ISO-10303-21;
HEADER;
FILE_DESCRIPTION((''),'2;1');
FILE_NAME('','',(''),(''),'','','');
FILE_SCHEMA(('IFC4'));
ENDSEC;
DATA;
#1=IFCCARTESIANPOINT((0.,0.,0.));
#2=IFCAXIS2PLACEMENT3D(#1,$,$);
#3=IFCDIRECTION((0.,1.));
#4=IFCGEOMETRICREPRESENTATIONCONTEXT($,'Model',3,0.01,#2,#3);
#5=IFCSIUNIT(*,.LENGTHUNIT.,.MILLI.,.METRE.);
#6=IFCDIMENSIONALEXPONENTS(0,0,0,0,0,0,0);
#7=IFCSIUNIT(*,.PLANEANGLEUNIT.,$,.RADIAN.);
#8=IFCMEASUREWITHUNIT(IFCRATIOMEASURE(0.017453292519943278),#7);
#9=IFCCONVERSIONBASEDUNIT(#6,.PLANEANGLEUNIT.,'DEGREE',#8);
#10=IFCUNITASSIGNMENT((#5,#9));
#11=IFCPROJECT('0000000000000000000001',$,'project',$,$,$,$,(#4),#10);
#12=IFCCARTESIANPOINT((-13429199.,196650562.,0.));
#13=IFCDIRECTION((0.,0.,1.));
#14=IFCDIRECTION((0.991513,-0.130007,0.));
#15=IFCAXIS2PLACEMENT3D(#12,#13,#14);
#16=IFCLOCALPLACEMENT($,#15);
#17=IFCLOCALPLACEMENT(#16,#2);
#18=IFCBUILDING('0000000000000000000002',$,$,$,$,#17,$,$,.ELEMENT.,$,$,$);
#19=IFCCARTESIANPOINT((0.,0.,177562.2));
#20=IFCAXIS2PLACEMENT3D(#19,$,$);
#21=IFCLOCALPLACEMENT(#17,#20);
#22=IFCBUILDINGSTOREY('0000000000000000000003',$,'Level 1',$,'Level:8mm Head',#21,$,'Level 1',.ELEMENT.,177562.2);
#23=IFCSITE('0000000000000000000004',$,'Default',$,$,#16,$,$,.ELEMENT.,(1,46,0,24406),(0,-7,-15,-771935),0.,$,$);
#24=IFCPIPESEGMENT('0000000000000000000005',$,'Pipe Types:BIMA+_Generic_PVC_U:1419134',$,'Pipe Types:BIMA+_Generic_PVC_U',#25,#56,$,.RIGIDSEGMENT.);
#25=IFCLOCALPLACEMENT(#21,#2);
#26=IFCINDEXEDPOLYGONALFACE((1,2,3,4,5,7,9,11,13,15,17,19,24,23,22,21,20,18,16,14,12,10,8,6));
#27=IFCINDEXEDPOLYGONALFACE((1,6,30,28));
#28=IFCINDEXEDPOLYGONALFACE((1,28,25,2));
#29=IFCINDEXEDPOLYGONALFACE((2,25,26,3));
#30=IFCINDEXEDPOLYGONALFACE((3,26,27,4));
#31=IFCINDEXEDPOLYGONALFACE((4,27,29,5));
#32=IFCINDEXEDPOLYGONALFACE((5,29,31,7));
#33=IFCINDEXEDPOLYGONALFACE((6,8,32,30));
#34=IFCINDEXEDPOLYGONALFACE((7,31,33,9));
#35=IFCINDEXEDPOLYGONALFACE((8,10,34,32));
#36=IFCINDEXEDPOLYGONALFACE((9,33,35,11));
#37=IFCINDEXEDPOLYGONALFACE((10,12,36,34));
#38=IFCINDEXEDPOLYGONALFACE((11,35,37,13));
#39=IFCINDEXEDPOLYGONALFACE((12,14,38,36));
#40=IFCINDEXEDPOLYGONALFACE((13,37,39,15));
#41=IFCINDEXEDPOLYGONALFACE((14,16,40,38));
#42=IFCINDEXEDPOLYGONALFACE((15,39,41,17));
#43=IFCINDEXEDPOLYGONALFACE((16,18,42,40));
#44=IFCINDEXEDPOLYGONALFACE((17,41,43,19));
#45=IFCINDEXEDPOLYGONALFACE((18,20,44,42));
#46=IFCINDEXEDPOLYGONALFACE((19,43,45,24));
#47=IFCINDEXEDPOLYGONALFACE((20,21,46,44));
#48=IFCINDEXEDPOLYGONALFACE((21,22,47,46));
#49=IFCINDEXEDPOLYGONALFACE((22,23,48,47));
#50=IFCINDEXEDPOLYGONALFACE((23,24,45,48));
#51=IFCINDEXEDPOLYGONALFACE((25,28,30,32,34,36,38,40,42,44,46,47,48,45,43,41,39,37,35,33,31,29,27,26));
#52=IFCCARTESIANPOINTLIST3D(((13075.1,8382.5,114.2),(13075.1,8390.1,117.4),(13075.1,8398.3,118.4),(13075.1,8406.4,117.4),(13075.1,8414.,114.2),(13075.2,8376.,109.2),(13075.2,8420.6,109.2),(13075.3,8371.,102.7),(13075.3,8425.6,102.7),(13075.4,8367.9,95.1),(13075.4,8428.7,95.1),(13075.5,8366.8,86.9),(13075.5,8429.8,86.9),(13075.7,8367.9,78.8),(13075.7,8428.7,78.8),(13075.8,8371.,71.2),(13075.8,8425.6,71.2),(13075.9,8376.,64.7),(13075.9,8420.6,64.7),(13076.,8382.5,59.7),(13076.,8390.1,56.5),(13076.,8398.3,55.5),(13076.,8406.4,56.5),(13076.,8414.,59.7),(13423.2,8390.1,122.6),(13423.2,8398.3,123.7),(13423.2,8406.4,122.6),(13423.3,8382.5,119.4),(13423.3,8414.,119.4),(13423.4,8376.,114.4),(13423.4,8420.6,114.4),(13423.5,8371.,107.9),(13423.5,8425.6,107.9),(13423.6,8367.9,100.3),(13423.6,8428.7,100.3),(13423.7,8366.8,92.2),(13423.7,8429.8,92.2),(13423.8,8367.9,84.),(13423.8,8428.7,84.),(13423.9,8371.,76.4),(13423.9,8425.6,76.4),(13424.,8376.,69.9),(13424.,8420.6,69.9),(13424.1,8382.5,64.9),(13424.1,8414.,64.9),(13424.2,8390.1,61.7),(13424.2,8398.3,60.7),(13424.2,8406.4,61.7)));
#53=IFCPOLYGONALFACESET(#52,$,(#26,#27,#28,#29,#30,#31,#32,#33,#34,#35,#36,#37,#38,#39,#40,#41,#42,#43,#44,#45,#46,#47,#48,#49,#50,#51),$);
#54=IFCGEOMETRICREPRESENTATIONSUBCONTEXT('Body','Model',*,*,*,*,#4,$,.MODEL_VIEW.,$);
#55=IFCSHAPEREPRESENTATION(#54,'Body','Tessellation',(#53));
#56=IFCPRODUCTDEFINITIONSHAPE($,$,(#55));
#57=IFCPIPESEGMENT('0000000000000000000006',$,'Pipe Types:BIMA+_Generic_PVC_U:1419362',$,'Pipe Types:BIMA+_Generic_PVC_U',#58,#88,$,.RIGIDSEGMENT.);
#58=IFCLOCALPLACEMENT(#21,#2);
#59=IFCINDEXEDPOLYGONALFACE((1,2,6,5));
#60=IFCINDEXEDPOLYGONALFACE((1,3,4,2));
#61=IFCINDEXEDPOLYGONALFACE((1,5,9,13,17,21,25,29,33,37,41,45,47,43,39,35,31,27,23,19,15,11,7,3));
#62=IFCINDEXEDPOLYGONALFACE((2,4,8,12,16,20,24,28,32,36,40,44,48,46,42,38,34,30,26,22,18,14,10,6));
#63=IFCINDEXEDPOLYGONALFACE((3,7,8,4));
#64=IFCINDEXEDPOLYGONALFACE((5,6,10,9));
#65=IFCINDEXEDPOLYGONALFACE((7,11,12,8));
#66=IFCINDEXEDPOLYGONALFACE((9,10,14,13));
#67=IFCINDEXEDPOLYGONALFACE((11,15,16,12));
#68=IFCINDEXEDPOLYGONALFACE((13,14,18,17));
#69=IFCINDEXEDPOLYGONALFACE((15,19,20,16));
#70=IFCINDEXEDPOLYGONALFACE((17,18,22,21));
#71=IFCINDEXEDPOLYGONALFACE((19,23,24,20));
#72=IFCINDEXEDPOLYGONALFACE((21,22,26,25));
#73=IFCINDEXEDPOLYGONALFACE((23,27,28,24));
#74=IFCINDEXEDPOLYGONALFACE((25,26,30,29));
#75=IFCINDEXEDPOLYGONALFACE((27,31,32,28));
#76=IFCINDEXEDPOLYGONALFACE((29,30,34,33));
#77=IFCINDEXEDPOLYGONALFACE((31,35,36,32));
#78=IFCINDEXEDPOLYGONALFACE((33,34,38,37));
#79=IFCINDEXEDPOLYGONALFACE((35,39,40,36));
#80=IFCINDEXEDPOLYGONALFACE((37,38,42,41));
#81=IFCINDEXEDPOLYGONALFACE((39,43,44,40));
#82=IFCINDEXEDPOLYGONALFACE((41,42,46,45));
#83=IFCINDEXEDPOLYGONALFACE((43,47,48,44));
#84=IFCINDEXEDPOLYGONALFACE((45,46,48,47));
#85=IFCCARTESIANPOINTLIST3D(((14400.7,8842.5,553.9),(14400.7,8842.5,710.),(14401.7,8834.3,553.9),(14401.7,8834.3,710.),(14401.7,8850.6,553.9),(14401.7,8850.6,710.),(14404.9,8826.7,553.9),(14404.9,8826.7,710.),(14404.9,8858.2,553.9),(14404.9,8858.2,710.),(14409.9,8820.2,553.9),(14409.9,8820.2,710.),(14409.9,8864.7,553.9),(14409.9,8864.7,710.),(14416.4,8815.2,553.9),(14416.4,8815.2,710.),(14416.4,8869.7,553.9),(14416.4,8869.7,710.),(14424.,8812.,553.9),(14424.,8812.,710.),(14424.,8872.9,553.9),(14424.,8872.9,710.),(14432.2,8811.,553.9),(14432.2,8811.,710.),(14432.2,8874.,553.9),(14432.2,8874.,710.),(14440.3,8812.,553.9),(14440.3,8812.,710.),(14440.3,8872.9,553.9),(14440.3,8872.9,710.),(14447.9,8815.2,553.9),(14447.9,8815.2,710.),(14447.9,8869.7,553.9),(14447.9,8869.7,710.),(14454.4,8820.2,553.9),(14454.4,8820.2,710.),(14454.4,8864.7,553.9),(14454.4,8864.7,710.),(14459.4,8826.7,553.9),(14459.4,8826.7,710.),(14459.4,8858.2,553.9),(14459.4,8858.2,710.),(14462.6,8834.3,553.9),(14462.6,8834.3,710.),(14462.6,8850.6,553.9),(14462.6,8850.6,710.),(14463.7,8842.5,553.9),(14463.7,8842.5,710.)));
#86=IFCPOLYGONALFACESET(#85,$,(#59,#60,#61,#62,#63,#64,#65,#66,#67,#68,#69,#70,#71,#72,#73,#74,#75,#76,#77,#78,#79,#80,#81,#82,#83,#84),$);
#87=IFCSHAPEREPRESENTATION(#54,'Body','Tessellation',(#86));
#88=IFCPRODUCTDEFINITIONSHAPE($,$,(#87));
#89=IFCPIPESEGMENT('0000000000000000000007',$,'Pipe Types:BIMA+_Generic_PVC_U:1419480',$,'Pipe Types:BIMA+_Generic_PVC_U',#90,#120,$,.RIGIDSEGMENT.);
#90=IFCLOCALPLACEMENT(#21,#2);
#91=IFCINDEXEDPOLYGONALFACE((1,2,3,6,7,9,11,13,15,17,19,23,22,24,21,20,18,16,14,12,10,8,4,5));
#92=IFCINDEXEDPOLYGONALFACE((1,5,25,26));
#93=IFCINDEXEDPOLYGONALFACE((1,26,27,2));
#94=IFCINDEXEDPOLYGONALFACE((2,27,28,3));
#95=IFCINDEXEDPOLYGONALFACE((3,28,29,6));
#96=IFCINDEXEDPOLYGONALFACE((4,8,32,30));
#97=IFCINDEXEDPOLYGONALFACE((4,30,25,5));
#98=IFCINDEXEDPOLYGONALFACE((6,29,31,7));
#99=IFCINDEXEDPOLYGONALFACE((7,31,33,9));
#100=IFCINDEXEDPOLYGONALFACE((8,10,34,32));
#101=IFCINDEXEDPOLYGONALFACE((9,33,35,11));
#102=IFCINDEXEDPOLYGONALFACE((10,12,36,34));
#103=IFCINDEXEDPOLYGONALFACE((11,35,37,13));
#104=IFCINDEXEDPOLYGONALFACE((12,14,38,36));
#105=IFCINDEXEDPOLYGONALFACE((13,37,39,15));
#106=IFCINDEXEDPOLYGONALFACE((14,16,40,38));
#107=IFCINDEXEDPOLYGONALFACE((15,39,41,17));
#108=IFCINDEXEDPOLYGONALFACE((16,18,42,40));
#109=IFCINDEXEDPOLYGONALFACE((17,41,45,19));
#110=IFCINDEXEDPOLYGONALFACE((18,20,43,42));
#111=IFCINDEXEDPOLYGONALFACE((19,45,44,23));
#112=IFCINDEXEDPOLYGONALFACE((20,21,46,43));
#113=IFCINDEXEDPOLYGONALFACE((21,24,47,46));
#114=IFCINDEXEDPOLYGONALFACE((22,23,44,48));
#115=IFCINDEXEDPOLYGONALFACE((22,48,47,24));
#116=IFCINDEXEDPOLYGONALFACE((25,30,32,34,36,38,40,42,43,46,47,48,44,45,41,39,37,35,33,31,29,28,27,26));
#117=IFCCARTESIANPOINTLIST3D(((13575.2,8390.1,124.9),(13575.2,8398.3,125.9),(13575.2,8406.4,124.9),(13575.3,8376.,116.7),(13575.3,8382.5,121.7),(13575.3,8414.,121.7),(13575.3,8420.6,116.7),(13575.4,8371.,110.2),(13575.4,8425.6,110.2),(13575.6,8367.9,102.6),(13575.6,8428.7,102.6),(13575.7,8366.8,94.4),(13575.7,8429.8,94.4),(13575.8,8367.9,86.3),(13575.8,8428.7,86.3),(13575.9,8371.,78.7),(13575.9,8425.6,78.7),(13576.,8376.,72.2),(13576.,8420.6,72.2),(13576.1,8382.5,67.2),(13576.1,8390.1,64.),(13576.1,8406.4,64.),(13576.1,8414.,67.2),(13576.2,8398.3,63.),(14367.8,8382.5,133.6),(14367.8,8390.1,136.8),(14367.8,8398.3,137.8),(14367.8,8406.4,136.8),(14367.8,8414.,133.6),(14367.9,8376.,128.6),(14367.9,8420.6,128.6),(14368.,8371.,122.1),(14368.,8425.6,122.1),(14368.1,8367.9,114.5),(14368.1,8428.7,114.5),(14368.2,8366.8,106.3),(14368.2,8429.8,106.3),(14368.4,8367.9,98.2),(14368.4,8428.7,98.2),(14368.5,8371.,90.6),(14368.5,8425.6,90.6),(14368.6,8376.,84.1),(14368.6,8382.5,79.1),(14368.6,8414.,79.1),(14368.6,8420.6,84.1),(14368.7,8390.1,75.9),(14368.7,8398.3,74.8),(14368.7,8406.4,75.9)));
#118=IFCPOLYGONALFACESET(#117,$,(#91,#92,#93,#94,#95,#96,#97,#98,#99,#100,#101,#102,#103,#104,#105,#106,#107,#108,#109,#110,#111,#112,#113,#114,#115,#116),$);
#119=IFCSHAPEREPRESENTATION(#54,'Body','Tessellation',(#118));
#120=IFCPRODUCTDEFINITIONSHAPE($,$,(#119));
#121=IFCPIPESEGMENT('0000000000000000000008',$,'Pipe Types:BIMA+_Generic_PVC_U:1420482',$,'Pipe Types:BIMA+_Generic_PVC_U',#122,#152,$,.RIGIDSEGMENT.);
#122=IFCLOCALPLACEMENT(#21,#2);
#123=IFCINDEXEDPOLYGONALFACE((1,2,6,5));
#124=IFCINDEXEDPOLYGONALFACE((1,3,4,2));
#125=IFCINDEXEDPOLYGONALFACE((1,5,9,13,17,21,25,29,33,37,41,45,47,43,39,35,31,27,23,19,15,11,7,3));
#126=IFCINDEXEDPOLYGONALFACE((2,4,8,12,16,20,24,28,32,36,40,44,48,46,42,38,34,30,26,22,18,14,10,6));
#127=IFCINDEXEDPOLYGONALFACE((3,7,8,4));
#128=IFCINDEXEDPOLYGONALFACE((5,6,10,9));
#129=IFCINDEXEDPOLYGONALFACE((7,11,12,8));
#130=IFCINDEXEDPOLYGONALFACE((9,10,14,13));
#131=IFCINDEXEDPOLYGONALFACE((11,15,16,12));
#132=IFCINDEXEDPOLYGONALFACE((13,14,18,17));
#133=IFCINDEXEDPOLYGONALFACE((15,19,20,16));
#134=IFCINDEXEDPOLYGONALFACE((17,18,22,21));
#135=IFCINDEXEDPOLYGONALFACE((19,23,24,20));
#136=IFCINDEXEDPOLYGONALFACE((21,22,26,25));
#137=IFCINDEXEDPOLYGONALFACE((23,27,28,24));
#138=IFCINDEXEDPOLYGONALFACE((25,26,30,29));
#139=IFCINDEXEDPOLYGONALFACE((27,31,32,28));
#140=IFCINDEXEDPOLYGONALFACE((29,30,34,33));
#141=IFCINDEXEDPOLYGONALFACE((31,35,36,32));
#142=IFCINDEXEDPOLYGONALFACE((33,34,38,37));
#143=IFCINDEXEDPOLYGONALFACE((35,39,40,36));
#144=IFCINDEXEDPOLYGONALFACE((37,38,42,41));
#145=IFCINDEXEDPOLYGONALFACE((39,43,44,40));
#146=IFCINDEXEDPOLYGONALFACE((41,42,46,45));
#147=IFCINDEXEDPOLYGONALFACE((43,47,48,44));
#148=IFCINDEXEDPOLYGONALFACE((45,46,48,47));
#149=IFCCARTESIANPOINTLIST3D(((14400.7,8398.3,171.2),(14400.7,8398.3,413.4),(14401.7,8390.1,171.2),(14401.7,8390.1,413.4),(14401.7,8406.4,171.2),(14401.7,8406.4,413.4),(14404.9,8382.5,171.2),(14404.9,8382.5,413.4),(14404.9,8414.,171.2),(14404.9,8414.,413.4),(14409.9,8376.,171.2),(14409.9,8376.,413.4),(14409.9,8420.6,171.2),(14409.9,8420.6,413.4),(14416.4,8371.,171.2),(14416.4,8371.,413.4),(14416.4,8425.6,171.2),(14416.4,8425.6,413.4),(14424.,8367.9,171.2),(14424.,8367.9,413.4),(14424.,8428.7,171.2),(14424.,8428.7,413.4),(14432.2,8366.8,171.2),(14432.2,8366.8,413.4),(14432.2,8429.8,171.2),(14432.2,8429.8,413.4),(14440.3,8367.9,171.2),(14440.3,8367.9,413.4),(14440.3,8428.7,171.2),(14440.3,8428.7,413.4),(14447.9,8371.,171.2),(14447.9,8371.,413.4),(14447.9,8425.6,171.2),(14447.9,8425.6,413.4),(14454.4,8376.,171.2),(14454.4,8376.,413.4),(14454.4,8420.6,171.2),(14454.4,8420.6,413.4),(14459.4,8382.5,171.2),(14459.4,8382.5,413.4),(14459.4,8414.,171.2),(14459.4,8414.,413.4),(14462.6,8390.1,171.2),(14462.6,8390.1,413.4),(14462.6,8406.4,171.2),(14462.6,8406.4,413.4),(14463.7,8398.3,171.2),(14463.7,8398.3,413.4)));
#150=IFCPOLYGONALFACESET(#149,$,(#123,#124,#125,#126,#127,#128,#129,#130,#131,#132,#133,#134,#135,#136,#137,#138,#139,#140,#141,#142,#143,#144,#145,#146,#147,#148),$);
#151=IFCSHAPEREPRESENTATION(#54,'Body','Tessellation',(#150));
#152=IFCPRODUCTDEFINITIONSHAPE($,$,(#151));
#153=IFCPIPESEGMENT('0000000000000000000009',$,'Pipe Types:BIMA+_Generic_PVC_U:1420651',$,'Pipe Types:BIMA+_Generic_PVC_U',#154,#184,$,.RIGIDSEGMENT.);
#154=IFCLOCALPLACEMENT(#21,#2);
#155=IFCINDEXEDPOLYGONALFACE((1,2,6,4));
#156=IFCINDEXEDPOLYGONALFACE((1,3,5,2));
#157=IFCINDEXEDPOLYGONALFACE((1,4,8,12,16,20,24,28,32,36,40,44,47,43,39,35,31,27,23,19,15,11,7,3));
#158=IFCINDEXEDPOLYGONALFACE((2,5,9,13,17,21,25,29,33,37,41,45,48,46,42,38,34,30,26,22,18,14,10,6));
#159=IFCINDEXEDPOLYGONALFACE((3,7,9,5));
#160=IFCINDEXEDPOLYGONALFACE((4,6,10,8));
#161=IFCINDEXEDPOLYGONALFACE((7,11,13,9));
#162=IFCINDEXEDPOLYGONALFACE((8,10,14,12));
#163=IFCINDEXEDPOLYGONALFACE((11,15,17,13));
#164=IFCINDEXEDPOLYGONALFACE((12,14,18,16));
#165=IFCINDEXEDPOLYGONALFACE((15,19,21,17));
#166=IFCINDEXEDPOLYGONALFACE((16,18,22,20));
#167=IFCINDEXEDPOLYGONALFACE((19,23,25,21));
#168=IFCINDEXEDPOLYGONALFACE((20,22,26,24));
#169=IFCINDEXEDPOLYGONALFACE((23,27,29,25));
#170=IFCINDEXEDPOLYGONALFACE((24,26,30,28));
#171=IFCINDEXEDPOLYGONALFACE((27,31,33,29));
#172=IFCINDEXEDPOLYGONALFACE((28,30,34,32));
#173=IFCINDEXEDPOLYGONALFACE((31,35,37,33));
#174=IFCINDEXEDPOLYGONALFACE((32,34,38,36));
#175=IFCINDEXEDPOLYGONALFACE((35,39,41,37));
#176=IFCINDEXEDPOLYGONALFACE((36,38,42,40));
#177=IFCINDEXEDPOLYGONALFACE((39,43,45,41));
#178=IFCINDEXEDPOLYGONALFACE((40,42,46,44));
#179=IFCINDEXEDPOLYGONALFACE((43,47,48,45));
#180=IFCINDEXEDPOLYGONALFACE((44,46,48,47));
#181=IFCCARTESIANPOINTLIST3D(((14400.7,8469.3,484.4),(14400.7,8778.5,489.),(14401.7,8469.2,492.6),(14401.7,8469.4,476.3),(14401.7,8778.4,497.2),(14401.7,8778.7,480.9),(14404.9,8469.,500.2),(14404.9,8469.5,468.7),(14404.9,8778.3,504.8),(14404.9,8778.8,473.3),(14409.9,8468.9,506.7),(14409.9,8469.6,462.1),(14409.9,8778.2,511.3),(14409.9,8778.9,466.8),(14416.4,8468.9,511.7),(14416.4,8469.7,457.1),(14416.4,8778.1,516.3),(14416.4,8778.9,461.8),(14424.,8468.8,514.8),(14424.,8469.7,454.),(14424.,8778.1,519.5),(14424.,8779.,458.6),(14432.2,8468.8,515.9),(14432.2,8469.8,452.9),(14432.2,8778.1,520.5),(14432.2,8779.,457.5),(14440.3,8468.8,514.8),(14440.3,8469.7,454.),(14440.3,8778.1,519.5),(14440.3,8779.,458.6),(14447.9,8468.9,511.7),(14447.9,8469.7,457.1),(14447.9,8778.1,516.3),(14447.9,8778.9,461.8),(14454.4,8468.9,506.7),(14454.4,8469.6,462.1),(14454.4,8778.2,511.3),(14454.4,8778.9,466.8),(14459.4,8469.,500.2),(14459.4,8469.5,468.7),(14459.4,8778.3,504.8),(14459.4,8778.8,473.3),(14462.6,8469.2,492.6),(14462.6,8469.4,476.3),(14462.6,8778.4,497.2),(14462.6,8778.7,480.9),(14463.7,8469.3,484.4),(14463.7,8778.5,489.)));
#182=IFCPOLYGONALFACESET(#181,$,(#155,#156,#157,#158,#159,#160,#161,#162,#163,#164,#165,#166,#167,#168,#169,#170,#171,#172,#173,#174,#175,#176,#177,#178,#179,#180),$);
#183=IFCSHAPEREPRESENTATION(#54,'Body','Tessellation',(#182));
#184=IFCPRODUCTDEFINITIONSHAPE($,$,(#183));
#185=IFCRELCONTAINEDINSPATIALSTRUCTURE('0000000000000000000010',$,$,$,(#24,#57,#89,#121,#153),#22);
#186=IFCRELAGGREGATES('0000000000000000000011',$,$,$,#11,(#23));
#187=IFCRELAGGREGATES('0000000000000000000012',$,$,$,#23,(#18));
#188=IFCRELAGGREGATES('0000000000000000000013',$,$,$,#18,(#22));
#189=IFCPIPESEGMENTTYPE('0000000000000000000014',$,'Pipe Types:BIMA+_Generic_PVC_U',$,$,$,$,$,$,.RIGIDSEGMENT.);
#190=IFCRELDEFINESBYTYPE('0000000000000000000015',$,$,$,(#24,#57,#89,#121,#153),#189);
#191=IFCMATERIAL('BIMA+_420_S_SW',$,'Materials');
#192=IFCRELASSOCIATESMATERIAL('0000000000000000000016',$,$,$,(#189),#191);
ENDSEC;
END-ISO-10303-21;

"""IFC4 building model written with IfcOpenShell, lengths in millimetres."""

from ifc_helpers import new_model, entity, si_unit, converted_unit, direction, frame, origin, place, context, subcontext, project, spatial, arc, indexed_curve, outline, extrude, material, type_object, element, save


model = new_model("IFC4")

# Units and contexts
model_context = context("Model", 3, precision=0.01, world=origin(), true_north=direction((0.0, 1.0)))
body_context = subcontext(model_context, "Body", "Model", "MODEL_VIEW")
ifc_project = project(units=[si_unit("LENGTHUNIT", "METRE", prefix="MILLI"), converted_unit("PLANEANGLEUNIT", "DEGREE", entity("IfcRatioMeasure", 0.017453292519943278), si_unit("PLANEANGLEUNIT", "RADIAN"), dimensions=[0, 0, 0, 0, 0, 0, 0])], contexts=[model_context])

# Site, building, storey
site_placement = place(None, frame((-13429199.0, 196650562.0, 0.0), z_axis=(0.0, 0.0, 1.0), x_axis=(0.991513, -0.130007, 0.0)))
site = spatial("IfcSite", under=ifc_project, at=site_placement, Name="Default", CompositionType="ELEMENT", RefLatitude=(1, 46, 0, 24406), RefLongitude=(0, -7, -15, -771935), RefElevation=0.0)
building_placement = place(site_placement, origin())
building = spatial("IfcBuilding", under=site, at=building_placement, CompositionType="ELEMENT")
storey_placement = place(building_placement, frame((0.0, 0.0, 177562.2)))
storey = spatial("IfcBuildingStorey", under=building, at=storey_placement, Name="Level 1", ObjectType="Level:8mm Head", LongName="Level 1", CompositionType="ELEMENT", Elevation=177562.2)

# Pipe segments
ifc_material_1 = material(Name="BIMA+_420_S_SW", Category="Materials")
pipe_segment_type_1 = type_object("IfcPipeSegmentType", Name="Pipe Types:BIMA+_Generic_PVC_U", PredefinedType="RIGIDSEGMENT", material=ifc_material_1)
pipe_segment_1_placement = place(storey_placement, frame((13073.5, 8365.2, 53.9)))
element("IfcPipeSegment", 1, at=pipe_segment_1_placement, inside=storey, type_object=pipe_segment_type_1, Name="Pipe Types:BIMA+_Generic_PVC_U:1419134", ObjectType="Pipe Types:BIMA+_Generic_PVC_U", PredefinedType="RIGIDSEGMENT", context=body_context, shape_type="SweptSolid", body=[
    extrude(outline(indexed_curve([(31.5, 0.0), (22.3, 22.3), (0.0, 31.5), (-22.3, 22.3), (-31.5, 0.0), (-22.3, -22.3), (0.0, -31.5), (22.3, -22.3)], segments=[arc(1, 2, 3), arc(3, 4, 5), arc(5, 6, 7), arc(7, 8, 1)], self_intersect=False)), frame((2.1, 33.1, 33.1), z_axis=(0.999888, 0.0, 0.014998), x_axis=(0.0, 1.0, 0.0)), (0.0, 0.0, 1.0), 348.2),
])
pipe_segment_2_placement = place(storey_placement, frame((14399.1, 8809.4, 710.0)))
element("IfcPipeSegment", 2, at=pipe_segment_2_placement, inside=storey, type_object=pipe_segment_type_1, Name="Pipe Types:BIMA+_Generic_PVC_U:1419362", ObjectType="Pipe Types:BIMA+_Generic_PVC_U", PredefinedType="RIGIDSEGMENT", context=body_context, shape_type="SweptSolid", body=[
    extrude(outline(indexed_curve([(31.5, 0.0), (22.3, 22.3), (0.0, 31.5), (-22.3, 22.3), (-31.5, 0.0), (-22.3, -22.3), (0.0, -31.5), (22.3, -22.3)], segments=[arc(1, 2, 3), arc(3, 4, 5), arc(5, 6, 7), arc(7, 8, 1)], self_intersect=False)), frame((33.1, 33.1, -156.1)), (0.0, 0.0, 1.0), 156.1),
])
pipe_segment_3_placement = place(storey_placement, frame((13573.6, 8365.2, 61.4)))
element("IfcPipeSegment", 3, at=pipe_segment_3_placement, inside=storey, type_object=pipe_segment_type_1, Name="Pipe Types:BIMA+_Generic_PVC_U:1419480", ObjectType="Pipe Types:BIMA+_Generic_PVC_U", PredefinedType="RIGIDSEGMENT", context=body_context, shape_type="SweptSolid", body=[
    extrude(outline(indexed_curve([(31.5, 0.0), (22.3, 22.3), (0.0, 31.5), (-22.3, 22.3), (-31.5, 0.0), (-22.3, -22.3), (0.0, -31.5), (22.3, -22.3)], segments=[arc(1, 2, 3), arc(3, 4, 5), arc(5, 6, 7), arc(7, 8, 1)], self_intersect=False)), frame((2.1, 33.1, 33.1), z_axis=(0.999888, 0.0, 0.014998), x_axis=(0.0, -1.0, 0.0)), (0.0, 0.0, 1.0), 792.6),
])
pipe_segment_4_placement = place(storey_placement, frame((14399.1, 8365.2, 171.2)))
element("IfcPipeSegment", 4, at=pipe_segment_4_placement, inside=storey, type_object=pipe_segment_type_1, Name="Pipe Types:BIMA+_Generic_PVC_U:1420482", ObjectType="Pipe Types:BIMA+_Generic_PVC_U", PredefinedType="RIGIDSEGMENT", context=body_context, shape_type="SweptSolid", body=[
    extrude(outline(indexed_curve([(31.5, 0.0), (22.3, 22.3), (0.0, 31.5), (-22.3, 22.3), (-31.5, 0.0), (-22.3, -22.3), (0.0, -31.5), (22.3, -22.3)], segments=[arc(1, 2, 3), arc(3, 4, 5), arc(5, 6, 7), arc(7, 8, 1)], self_intersect=False)), frame((33.1, 33.1, 0.0), z_axis=(0.0, 0.0, 1.0), x_axis=(-1.0, 0.0, 0.0)), (0.0, 0.0, 1.0), 242.2),
])
pipe_segment_5_placement = place(storey_placement, frame((14399.1, 8467.2, 451.3)))
element("IfcPipeSegment", 5, at=pipe_segment_5_placement, inside=storey, type_object=pipe_segment_type_1, Name="Pipe Types:BIMA+_Generic_PVC_U:1420651", ObjectType="Pipe Types:BIMA+_Generic_PVC_U", PredefinedType="RIGIDSEGMENT", context=body_context, shape_type="SweptSolid", body=[
    extrude(outline(indexed_curve([(31.5, 0.0), (22.3, 22.3), (0.0, 31.5), (-22.3, 22.3), (-31.5, 0.0), (-22.3, -22.3), (0.0, -31.5), (22.3, -22.3)], segments=[arc(1, 2, 3), arc(3, 4, 5), arc(5, 6, 7), arc(7, 8, 1)], self_intersect=False)), frame((33.1, 2.1, 33.1), z_axis=(0.0, 0.999888, 0.014998), x_axis=(1.0, 0.0, 0.0)), (0.0, 0.0, 1.0), 309.3),
])

save(model, "model.ifc")
